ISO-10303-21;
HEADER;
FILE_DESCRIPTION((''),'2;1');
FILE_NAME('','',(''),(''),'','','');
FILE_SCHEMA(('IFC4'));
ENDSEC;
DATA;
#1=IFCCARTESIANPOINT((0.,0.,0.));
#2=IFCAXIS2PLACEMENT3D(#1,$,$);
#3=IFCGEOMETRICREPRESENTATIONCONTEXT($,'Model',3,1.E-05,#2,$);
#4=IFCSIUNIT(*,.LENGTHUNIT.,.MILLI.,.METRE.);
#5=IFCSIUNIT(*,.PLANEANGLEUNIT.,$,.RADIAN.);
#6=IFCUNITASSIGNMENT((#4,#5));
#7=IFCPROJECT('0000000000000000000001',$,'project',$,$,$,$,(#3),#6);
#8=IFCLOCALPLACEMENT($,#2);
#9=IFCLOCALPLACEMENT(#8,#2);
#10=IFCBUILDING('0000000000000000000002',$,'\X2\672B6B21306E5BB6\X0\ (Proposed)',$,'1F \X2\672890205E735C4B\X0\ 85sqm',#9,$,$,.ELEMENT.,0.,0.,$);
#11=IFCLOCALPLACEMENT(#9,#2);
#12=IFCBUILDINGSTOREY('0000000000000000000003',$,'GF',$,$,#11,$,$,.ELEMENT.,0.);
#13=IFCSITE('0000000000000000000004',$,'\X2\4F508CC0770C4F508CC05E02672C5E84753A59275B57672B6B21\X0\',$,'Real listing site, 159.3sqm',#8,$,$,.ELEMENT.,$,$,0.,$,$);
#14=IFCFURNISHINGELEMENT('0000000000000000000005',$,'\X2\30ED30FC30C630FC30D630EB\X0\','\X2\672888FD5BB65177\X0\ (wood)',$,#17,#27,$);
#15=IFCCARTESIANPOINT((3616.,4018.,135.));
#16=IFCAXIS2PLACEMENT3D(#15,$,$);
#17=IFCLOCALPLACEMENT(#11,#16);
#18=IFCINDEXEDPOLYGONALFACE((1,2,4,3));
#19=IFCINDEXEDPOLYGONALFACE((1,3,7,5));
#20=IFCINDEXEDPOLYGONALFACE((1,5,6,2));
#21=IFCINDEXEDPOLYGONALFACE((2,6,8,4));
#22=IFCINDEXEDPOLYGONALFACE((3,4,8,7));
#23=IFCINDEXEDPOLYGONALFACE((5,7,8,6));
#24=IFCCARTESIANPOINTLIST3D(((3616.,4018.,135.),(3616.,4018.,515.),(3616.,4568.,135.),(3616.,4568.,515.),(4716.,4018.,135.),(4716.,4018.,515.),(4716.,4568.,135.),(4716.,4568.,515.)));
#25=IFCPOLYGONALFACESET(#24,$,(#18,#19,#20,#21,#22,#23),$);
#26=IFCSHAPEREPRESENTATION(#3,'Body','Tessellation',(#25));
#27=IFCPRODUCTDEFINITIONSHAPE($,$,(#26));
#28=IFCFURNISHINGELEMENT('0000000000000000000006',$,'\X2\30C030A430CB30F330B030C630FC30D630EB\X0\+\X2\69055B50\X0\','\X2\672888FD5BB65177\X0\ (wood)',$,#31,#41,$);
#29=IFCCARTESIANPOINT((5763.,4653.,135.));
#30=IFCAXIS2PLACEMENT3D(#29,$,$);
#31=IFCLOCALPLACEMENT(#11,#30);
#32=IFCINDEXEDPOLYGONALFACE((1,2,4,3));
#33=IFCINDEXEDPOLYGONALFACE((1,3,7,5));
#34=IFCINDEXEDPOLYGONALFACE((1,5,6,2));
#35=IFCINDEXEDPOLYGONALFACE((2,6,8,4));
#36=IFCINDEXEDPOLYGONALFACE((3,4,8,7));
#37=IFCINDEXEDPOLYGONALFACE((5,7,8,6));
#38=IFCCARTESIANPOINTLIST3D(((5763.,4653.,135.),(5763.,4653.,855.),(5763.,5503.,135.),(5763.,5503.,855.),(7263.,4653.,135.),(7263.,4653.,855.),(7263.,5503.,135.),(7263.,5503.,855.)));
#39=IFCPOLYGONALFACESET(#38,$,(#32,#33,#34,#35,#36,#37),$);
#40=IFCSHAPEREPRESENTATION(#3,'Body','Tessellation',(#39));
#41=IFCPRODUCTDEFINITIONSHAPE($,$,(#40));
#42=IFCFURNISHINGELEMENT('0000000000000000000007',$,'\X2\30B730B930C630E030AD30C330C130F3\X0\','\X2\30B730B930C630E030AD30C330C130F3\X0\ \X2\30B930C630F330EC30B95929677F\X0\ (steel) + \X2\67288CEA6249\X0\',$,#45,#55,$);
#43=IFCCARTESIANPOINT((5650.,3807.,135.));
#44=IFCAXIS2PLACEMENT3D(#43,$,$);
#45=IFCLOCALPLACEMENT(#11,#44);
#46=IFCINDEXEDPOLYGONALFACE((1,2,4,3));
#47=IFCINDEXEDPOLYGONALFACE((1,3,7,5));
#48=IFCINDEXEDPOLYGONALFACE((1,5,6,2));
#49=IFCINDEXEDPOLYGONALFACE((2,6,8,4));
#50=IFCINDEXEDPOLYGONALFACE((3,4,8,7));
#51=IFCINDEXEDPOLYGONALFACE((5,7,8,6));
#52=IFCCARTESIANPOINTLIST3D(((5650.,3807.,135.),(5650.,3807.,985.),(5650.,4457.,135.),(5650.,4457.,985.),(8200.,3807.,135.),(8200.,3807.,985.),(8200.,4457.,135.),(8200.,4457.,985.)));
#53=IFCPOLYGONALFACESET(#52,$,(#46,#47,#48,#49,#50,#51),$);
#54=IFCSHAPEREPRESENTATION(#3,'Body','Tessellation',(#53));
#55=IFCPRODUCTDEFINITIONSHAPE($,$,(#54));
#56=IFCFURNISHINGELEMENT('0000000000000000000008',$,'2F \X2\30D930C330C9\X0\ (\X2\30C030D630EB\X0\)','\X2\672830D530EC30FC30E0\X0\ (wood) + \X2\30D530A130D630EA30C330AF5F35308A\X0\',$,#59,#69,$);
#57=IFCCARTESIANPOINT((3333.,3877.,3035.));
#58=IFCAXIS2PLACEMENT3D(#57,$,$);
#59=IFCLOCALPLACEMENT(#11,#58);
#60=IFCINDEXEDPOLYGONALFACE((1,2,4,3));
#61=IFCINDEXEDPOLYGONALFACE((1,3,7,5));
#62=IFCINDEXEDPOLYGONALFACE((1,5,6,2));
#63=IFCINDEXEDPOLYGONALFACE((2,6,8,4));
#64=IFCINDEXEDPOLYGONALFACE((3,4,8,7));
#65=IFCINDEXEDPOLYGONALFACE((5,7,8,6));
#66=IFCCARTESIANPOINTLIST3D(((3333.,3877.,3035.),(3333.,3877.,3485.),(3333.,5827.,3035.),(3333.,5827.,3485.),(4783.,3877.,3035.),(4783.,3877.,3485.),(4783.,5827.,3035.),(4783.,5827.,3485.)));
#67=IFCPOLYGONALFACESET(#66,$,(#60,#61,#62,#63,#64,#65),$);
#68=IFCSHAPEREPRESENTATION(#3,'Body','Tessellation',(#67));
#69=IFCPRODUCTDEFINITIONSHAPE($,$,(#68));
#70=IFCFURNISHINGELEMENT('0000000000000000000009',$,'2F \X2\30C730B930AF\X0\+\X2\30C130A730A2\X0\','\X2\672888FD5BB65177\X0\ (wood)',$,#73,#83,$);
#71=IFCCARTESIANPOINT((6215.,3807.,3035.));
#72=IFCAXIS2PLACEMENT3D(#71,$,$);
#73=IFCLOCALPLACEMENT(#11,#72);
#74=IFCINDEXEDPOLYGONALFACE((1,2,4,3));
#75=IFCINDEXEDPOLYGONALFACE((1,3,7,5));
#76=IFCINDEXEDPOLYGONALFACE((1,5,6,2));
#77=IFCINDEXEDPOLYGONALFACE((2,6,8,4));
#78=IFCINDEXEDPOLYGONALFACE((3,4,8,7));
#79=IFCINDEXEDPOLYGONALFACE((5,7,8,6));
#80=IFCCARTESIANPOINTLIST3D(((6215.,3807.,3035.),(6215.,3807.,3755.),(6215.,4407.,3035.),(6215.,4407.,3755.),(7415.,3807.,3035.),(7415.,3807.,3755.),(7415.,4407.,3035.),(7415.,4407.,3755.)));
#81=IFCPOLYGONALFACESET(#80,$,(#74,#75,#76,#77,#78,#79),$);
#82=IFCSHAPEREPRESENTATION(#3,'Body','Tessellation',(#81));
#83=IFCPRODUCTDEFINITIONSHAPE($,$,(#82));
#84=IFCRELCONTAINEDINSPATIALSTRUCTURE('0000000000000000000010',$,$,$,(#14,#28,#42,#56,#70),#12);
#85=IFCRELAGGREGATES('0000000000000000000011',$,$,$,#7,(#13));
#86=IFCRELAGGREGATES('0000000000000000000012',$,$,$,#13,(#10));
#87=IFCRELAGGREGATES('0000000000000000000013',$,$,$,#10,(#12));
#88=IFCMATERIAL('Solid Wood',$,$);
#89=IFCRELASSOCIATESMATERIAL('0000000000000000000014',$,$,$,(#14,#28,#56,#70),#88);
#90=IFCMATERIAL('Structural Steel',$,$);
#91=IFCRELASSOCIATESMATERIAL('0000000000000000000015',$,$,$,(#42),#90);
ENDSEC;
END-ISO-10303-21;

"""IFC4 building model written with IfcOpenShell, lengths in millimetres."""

from ifc_helpers import new_model, si_unit, frame, frame_2d, origin, place, context, project, spatial, rectangle, extrude, material, element, save


model = new_model("IFC4")

# Units and contexts
model_context = context("Model", 3, precision=1e-05, world=origin())
ifc_project = project(units=[si_unit("LENGTHUNIT", "METRE", prefix="MILLI"), si_unit("PLANEANGLEUNIT", "RADIAN")], contexts=[model_context])

# Site, building, storey
site_placement = place(None, origin())
site = spatial("IfcSite", under=ifc_project, at=site_placement, Name="佐賀県佐賀市本庄町大字末次", ObjectType="Real listing site, 159.3sqm", CompositionType="ELEMENT", RefElevation=0.0)
building_placement = place(site_placement, origin())
building = spatial("IfcBuilding", under=site, at=building_placement, Name="末次の家 (Proposed)", ObjectType="1F 木造平屋 85sqm", CompositionType="ELEMENT", ElevationOfRefHeight=0.0, ElevationOfTerrain=0.0)
storey_placement = place(building_placement, origin())
storey = spatial("IfcBuildingStorey", under=building, at=storey_placement, Name="GF", CompositionType="ELEMENT", Elevation=0.0)

# Shared definitions
ifc_material_1 = material(Name="Solid Wood")

# Shared definitions
ifc_material_2 = material(Name="Structural Steel")

# Furnishing elements
furnishing_1_placement = place(storey_placement, frame((3616.0, 4018.0, 135.0)))
element("IfcFurnishingElement", 1, at=furnishing_1_placement, inside=storey, material=ifc_material_1, Name="ローテーブル", Description="木製家具 (wood)", context=model_context, shape_type="SweptSolid", body=[
    extrude(rectangle(XDim=1100.0, YDim=550.0, at=frame_2d((550.0, 275.0))), frame((3616.0, 4018.0, 135.0)), (0.0, 0.0, 1.0), 380.0),
])
furnishing_2_placement = place(storey_placement, frame((5763.0, 4653.0, 135.0)))
element("IfcFurnishingElement", 2, at=furnishing_2_placement, inside=storey, material=ifc_material_1, Name="ダイニングテーブル+椅子", Description="木製家具 (wood)", context=model_context, shape_type="SweptSolid", body=[
    extrude(rectangle(XDim=1500.0, YDim=850.0, at=frame_2d((750.0, 425.0))), frame((5763.0, 4653.0, 135.0)), (0.0, 0.0, 1.0), 720.0),
])
furnishing_3_placement = place(storey_placement, frame((5650.0, 3807.0, 135.0)))
element("IfcFurnishingElement", 3, at=furnishing_3_placement, inside=storey, material=ifc_material_2, Name="システムキッチン", Description="システムキッチン ステンレス天板 (steel) + 木質扉", context=model_context, shape_type="SweptSolid", body=[
    extrude(rectangle(XDim=2550.0, YDim=650.0, at=frame_2d((1275.0, 325.0))), frame((5650.0, 3807.0, 135.0)), (0.0, 0.0, 1.0), 850.0),
])
furnishing_4_placement = place(storey_placement, frame((3333.0, 3877.0, 3035.0)))
element("IfcFurnishingElement", 4, at=furnishing_4_placement, inside=storey, material=ifc_material_1, Name="2F ベッド (ダブル)", Description="木フレーム (wood) + ファブリック張り", context=model_context, shape_type="SweptSolid", body=[
    extrude(rectangle(XDim=1450.0, YDim=1950.0, at=frame_2d((725.0, 975.0))), frame((3333.0, 3877.0, 3035.0)), (0.0, 0.0, 1.0), 450.0),
])
furnishing_5_placement = place(storey_placement, frame((6215.0, 3807.0, 3035.0)))
element("IfcFurnishingElement", 5, at=furnishing_5_placement, inside=storey, material=ifc_material_1, Name="2F デスク+チェア", Description="木製家具 (wood)", context=model_context, shape_type="SweptSolid", body=[
    extrude(rectangle(XDim=1200.0, YDim=600.0, at=frame_2d((600.0, 300.0))), frame((6215.0, 3807.0, 3035.0)), (0.0, 0.0, 1.0), 720.0),
])

save(model, "model.ifc")
